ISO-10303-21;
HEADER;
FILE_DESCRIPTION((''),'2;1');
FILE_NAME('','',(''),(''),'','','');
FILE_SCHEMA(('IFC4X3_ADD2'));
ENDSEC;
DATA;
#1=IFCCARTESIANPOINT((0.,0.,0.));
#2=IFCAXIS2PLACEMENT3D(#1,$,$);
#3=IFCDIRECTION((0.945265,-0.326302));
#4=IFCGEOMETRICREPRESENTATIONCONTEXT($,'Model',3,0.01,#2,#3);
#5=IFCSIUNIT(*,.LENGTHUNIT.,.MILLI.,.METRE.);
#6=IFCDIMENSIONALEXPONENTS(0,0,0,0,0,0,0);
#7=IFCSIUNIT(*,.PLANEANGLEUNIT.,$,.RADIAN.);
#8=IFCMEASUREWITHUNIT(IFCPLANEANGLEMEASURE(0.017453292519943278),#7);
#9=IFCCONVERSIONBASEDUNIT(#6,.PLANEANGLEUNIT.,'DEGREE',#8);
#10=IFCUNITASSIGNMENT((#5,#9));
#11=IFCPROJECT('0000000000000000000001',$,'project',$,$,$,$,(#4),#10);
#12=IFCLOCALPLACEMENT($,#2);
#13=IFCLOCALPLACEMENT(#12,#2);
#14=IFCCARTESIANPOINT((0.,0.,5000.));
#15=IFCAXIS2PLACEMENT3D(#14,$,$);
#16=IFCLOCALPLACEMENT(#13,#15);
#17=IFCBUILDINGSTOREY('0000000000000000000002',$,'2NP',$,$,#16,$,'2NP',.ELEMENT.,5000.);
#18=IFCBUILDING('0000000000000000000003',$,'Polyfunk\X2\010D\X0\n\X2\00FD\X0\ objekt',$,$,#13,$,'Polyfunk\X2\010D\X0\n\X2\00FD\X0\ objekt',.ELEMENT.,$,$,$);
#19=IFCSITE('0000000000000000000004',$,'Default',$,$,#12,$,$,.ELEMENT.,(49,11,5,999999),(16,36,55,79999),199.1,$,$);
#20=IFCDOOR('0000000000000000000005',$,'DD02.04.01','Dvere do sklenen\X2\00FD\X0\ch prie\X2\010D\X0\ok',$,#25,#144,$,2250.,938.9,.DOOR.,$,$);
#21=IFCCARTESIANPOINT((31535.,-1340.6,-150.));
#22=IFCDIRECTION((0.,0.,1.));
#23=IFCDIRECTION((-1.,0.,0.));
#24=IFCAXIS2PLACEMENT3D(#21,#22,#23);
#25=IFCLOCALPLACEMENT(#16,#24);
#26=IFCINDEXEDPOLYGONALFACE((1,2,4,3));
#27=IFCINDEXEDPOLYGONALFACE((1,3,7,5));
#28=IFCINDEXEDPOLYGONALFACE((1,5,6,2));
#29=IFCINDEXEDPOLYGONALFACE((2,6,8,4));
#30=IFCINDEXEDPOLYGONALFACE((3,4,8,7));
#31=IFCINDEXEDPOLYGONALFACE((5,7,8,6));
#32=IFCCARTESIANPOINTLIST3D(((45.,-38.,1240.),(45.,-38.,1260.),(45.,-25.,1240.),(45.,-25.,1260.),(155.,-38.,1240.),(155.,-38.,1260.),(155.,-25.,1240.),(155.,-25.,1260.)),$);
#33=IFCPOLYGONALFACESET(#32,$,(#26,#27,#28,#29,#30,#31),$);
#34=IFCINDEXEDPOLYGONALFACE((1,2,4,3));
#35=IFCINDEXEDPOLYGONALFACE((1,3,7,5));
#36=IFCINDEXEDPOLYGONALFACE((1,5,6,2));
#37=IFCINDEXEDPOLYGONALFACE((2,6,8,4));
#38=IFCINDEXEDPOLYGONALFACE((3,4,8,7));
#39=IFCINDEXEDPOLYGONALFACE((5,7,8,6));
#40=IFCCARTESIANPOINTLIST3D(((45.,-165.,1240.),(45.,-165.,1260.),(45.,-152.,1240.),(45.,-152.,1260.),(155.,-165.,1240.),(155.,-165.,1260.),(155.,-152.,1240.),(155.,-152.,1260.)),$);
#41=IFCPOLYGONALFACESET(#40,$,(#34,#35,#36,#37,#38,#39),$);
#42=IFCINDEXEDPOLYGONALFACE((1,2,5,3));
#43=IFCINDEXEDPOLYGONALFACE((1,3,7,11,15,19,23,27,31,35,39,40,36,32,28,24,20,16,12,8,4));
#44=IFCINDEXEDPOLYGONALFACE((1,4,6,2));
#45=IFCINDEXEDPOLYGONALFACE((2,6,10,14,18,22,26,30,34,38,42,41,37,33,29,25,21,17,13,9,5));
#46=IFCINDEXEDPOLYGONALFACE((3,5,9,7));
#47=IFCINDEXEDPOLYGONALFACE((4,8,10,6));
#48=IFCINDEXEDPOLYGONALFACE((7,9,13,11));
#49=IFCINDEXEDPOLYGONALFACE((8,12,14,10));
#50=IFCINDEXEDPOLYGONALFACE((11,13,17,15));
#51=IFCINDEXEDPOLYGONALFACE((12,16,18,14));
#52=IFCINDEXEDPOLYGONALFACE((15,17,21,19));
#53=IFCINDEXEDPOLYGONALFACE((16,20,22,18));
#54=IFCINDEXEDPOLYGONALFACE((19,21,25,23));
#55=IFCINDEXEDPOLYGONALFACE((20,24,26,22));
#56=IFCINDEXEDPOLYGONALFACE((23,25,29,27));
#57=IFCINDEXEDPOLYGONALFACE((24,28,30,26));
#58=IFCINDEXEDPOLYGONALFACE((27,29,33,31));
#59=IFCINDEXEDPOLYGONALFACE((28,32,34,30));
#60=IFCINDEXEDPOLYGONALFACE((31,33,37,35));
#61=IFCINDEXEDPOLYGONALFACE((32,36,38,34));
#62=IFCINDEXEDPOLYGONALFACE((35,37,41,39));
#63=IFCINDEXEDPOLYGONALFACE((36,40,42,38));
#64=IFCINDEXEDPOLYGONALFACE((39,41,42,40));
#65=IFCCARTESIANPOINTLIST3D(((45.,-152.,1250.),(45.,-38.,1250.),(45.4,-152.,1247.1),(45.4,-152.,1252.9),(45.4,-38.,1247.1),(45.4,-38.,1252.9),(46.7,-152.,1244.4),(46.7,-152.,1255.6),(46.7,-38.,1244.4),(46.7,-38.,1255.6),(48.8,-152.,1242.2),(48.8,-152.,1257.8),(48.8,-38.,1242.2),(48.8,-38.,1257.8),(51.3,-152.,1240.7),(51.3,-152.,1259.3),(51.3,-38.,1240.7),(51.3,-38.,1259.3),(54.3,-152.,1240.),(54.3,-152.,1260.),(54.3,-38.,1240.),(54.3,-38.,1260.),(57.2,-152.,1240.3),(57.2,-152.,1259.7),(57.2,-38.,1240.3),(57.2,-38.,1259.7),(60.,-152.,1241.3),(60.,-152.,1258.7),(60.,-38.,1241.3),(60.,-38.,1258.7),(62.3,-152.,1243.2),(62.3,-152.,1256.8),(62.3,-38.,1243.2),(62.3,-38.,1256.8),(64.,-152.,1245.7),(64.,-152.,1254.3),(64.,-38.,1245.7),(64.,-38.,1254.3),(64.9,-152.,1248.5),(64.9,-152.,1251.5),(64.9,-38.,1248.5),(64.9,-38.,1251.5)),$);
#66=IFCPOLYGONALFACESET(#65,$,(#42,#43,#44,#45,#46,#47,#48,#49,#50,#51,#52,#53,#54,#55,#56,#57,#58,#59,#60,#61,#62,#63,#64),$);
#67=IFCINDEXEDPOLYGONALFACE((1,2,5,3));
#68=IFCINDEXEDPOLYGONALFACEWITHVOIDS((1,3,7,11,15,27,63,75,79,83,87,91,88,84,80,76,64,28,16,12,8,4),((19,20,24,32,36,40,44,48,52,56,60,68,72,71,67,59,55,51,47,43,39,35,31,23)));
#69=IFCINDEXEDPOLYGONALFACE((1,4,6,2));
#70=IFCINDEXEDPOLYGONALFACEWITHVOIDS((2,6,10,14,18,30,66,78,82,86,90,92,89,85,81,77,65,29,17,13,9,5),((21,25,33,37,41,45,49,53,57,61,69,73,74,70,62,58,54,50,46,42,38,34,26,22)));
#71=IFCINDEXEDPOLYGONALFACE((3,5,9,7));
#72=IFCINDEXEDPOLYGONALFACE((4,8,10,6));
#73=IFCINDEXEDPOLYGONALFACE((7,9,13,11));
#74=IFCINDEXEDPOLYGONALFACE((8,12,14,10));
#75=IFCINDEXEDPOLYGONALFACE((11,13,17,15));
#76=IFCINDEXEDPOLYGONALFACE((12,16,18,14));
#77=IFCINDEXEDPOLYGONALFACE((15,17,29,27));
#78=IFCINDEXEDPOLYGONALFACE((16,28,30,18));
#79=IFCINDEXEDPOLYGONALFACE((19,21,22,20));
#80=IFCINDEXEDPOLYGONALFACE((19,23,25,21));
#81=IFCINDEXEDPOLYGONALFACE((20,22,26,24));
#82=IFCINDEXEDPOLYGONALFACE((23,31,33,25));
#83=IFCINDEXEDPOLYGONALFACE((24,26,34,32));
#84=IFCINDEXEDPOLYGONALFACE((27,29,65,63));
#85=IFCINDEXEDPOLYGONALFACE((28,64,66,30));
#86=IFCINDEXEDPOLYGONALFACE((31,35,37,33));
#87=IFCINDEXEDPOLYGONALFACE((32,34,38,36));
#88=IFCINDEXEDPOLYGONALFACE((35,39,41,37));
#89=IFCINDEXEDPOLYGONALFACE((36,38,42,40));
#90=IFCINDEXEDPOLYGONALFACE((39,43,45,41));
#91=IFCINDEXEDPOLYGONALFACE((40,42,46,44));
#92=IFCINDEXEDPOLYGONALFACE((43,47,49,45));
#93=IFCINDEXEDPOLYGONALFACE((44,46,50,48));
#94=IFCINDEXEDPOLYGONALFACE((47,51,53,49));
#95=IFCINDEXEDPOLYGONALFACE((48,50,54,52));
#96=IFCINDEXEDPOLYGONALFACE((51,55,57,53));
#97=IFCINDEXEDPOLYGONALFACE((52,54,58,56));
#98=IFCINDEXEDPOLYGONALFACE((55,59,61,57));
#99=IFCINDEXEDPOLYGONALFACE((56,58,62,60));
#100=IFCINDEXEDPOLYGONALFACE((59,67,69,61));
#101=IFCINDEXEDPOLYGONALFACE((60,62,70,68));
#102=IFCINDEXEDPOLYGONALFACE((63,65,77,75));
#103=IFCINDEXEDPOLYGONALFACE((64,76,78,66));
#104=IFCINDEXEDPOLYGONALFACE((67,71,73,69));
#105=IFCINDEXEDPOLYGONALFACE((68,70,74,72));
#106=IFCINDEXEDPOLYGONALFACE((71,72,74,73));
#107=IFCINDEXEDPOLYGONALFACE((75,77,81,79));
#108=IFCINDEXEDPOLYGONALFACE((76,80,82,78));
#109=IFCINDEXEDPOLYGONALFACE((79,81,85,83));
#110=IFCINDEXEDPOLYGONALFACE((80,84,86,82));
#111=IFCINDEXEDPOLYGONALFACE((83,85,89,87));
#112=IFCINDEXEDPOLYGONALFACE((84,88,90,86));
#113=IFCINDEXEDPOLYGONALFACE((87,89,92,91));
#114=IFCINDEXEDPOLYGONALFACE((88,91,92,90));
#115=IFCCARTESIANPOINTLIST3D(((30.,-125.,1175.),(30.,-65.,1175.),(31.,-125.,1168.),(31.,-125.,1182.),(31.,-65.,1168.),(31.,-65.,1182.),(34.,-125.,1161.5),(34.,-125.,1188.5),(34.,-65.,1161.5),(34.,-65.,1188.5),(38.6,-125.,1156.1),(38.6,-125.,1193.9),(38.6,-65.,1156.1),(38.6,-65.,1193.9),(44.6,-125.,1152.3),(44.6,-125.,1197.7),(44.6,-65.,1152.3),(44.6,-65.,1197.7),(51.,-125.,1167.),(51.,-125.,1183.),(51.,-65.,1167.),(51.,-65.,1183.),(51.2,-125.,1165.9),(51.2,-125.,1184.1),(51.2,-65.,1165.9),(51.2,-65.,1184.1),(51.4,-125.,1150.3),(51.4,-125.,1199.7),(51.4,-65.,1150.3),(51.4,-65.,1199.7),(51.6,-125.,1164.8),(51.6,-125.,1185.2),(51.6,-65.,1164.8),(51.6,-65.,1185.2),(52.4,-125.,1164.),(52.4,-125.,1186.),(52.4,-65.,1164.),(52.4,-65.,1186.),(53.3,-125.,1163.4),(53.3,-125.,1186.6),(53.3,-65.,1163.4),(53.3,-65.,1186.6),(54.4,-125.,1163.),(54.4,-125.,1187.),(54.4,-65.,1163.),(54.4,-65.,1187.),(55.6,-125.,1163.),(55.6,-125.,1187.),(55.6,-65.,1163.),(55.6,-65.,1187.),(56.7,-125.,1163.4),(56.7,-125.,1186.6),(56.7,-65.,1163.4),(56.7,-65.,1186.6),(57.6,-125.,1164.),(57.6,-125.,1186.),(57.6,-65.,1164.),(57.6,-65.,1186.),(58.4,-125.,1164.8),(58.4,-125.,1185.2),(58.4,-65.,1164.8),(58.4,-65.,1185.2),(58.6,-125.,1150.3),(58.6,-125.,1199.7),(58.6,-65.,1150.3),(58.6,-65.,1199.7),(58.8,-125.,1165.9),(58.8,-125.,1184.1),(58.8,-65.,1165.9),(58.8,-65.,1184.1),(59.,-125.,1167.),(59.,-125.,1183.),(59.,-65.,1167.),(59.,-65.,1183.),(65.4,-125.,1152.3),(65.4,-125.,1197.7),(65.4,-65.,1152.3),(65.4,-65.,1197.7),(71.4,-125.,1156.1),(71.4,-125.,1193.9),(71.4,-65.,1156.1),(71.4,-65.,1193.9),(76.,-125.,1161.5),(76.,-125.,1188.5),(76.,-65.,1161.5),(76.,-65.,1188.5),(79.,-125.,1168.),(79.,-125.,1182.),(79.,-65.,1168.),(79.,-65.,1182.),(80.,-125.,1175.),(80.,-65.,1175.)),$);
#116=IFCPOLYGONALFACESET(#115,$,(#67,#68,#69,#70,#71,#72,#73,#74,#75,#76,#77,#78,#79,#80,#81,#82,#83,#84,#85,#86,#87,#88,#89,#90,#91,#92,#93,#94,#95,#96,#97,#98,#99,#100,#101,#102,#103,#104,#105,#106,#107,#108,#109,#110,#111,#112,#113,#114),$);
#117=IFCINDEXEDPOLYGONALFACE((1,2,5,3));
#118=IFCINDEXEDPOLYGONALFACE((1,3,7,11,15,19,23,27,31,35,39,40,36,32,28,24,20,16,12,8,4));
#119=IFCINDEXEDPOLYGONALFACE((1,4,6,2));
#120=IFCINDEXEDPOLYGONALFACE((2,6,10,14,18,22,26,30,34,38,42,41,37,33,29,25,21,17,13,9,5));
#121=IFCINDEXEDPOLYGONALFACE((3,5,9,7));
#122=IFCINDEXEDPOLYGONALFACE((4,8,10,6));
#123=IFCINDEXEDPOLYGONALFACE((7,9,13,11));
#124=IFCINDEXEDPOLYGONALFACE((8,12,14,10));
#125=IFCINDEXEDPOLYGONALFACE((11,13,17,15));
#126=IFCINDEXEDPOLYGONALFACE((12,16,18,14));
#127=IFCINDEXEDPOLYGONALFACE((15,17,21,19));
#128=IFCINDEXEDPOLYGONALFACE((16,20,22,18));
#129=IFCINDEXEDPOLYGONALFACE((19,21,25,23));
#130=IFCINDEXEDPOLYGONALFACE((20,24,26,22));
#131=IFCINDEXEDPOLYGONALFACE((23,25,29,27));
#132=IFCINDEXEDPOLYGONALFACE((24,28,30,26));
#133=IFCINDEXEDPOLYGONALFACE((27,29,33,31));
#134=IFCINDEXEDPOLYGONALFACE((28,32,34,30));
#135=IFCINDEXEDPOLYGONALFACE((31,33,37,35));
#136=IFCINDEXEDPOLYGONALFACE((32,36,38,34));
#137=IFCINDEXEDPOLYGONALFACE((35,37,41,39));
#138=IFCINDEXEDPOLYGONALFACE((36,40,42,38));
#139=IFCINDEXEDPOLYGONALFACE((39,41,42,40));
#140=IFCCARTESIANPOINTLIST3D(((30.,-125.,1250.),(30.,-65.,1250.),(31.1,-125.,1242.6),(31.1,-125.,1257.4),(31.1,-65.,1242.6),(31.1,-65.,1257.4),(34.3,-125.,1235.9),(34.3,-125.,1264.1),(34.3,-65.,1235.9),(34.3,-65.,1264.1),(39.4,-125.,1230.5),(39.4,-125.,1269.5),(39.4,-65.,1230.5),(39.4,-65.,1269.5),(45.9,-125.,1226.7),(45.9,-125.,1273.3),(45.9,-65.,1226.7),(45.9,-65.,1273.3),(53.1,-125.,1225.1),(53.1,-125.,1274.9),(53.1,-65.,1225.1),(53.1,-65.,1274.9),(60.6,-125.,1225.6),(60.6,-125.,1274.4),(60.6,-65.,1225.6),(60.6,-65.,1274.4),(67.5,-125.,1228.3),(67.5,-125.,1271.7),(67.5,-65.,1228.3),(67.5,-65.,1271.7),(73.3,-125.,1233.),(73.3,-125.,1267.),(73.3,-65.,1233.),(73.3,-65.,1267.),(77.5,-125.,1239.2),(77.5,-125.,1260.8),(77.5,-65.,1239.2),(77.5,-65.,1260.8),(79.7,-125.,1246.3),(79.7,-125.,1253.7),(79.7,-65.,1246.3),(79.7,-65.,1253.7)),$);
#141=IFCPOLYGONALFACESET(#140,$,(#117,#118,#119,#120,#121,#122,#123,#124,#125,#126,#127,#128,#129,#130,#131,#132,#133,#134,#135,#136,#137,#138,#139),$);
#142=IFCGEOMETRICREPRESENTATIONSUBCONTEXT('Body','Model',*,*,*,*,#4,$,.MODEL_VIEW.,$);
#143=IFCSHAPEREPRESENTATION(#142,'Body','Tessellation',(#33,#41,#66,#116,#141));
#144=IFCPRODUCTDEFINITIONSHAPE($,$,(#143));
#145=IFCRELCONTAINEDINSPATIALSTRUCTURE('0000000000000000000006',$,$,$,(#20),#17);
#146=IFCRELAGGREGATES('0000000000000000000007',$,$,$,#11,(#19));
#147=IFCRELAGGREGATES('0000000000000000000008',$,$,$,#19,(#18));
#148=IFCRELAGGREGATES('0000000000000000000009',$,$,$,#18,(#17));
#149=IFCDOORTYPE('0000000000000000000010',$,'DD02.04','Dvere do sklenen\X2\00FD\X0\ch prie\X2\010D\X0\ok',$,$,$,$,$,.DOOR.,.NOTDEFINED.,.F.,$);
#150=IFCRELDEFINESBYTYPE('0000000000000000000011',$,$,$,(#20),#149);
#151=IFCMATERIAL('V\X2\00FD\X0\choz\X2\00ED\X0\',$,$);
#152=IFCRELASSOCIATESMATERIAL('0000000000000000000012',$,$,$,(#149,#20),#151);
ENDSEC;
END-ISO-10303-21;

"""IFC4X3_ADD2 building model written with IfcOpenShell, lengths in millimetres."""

from ifc_helpers import new_model, entity, si_unit, converted_unit, direction, frame, frame_2d, origin, origin_2d_with_axis, place, context, subcontext, project, spatial, polyline, circle_curve, parameter, trimmed, segment, composite_curve, rectangle, circle, outline, extrude, source, transform, mapped, material, type_object, type_shapes, element, save


model = new_model("IFC4X3_ADD2")

# Units and contexts
model_context = context("Model", 3, precision=0.01, world=origin(), true_north=direction((0.945265, -0.326302)))
body_context = subcontext(model_context, "Body", "Model", "MODEL_VIEW")
ifc_project = project(units=[si_unit("LENGTHUNIT", "METRE", prefix="MILLI"), converted_unit("PLANEANGLEUNIT", "DEGREE", entity("IfcPlaneAngleMeasure", 0.017453292519943278), si_unit("PLANEANGLEUNIT", "RADIAN"), dimensions=[0, 0, 0, 0, 0, 0, 0])], contexts=[model_context])

# Site, building, storey
site_placement = place(None, origin())
site = spatial("IfcSite", under=ifc_project, at=site_placement, Name="Default", CompositionType="ELEMENT", RefLatitude=(49, 11, 5, 999999), RefLongitude=(16, 36, 55, 79999), RefElevation=199.1)
building_placement = place(site_placement, origin())
building = spatial("IfcBuilding", under=site, at=building_placement, Name="Polyfunkčný objekt", LongName="Polyfunkčný objekt", CompositionType="ELEMENT")
storey_placement = place(building_placement, frame((0.0, 0.0, 5000.0)))
storey = spatial("IfcBuildingStorey", under=building, at=storey_placement, Name="2NP", LongName="2NP", CompositionType="ELEMENT", Elevation=5000.0)

# Door
ifc_material_1 = material(Name="Výchozí")
door_type = type_object("IfcDoorType", Name="DD02.04", Description="Dvere do sklenených priečok", OperationType="NOTDEFINED", ParameterTakesPrecedence=False, PredefinedType="DOOR", material=ifc_material_1)
shared_shape_1 = source(origin(), body_context, "Body", "SweptSolid", [
    extrude(rectangle(XDim=110.0, YDim=13.0, at=frame_2d((0.0, 0.0), x_axis=(1.0, 0.0))), frame((100.0, -31.5, 1240.0)), (0.0, 0.0, 1.0), 20.0),
    extrude(rectangle(XDim=110.0, YDim=13.0, at=origin_2d_with_axis()), frame((100.0, -158.5, 1240.0), z_axis=(0.0, 0.0, 1.0), x_axis=(-1.0, 0.0, 0.0)), (0.0, 0.0, 1.0), 20.0),
    extrude(circle(Radius=10.0, at=origin_2d_with_axis()), frame((55.0, -152.0, 1250.0), z_axis=(0.0, 1.0, 0.0), x_axis=(-1.0, 0.0, 0.0)), (0.0, 0.0, 1.0), 114.0),
    extrude(outline(composite_curve([segment(trimmed(circle_curve(origin_2d_with_axis(), 25.0), [parameter(180.0)], [parameter(360.0)], True, "PARAMETER"), True, "CONTINUOUS"), segment(trimmed(circle_curve(origin_2d_with_axis(), 25.0), [parameter(0.0)], [parameter(180.0)], True, "PARAMETER"), True, "CONTINUOUS")], self_intersect=False), holes=[composite_curve([segment(trimmed(circle_curve(frame_2d((0.0, 8.0), x_axis=(1.0, 0.0)), 4.0), [parameter(0.0)], [parameter(180.0)], True, "PARAMETER"), False, "CONTINUOUS"), segment(polyline([(4.0, 8.0), (4.0, -8.0)]), True, "CONTINUOUS"), segment(trimmed(circle_curve(frame_2d((0.0, -8.0), x_axis=(1.0, 0.0)), 4.0), [parameter(180.0)], [parameter(0.0)], True, "PARAMETER"), False, "CONTINUOUS"), segment(polyline([(-4.0, -8.0), (-4.0, 8.0)]), True, "CONTINUOUS")], self_intersect=False)]), frame((55.0, -125.0, 1175.0), z_axis=(0.0, 1.0, 0.0), x_axis=(-1.0, 0.0, 0.0)), (0.0, 0.0, 1.0), 60.0),
    extrude(circle(Radius=25.0, at=frame_2d((0.0, 0.0), x_axis=(1.0, 0.0))), frame((55.0, -125.0, 1250.0), z_axis=(0.0, 1.0, 0.0), x_axis=(-1.0, 0.0, 0.0)), (0.0, 0.0, 1.0), 60.0),
])
type_shapes(door_type, [shared_shape_1])
door_placement = place(storey_placement, frame((31535.0, -1340.6, -150.0), z_axis=(0.0, 0.0, 1.0), x_axis=(-1.0, 0.0, 0.0)))
element("IfcDoor", 1, at=door_placement, inside=storey, type_object=door_type, material=ifc_material_1, Name="DD02.04.01", Description="Dvere do sklenených priečok", OverallHeight=2250.0, OverallWidth=938.9, PredefinedType="DOOR", context=body_context, shape_type="MappedRepresentation", body=[
    mapped(shared_shape_1, transform((0.0, 0.0, 0.0), scale=1.0)),
])

save(model, "model.ifc")
